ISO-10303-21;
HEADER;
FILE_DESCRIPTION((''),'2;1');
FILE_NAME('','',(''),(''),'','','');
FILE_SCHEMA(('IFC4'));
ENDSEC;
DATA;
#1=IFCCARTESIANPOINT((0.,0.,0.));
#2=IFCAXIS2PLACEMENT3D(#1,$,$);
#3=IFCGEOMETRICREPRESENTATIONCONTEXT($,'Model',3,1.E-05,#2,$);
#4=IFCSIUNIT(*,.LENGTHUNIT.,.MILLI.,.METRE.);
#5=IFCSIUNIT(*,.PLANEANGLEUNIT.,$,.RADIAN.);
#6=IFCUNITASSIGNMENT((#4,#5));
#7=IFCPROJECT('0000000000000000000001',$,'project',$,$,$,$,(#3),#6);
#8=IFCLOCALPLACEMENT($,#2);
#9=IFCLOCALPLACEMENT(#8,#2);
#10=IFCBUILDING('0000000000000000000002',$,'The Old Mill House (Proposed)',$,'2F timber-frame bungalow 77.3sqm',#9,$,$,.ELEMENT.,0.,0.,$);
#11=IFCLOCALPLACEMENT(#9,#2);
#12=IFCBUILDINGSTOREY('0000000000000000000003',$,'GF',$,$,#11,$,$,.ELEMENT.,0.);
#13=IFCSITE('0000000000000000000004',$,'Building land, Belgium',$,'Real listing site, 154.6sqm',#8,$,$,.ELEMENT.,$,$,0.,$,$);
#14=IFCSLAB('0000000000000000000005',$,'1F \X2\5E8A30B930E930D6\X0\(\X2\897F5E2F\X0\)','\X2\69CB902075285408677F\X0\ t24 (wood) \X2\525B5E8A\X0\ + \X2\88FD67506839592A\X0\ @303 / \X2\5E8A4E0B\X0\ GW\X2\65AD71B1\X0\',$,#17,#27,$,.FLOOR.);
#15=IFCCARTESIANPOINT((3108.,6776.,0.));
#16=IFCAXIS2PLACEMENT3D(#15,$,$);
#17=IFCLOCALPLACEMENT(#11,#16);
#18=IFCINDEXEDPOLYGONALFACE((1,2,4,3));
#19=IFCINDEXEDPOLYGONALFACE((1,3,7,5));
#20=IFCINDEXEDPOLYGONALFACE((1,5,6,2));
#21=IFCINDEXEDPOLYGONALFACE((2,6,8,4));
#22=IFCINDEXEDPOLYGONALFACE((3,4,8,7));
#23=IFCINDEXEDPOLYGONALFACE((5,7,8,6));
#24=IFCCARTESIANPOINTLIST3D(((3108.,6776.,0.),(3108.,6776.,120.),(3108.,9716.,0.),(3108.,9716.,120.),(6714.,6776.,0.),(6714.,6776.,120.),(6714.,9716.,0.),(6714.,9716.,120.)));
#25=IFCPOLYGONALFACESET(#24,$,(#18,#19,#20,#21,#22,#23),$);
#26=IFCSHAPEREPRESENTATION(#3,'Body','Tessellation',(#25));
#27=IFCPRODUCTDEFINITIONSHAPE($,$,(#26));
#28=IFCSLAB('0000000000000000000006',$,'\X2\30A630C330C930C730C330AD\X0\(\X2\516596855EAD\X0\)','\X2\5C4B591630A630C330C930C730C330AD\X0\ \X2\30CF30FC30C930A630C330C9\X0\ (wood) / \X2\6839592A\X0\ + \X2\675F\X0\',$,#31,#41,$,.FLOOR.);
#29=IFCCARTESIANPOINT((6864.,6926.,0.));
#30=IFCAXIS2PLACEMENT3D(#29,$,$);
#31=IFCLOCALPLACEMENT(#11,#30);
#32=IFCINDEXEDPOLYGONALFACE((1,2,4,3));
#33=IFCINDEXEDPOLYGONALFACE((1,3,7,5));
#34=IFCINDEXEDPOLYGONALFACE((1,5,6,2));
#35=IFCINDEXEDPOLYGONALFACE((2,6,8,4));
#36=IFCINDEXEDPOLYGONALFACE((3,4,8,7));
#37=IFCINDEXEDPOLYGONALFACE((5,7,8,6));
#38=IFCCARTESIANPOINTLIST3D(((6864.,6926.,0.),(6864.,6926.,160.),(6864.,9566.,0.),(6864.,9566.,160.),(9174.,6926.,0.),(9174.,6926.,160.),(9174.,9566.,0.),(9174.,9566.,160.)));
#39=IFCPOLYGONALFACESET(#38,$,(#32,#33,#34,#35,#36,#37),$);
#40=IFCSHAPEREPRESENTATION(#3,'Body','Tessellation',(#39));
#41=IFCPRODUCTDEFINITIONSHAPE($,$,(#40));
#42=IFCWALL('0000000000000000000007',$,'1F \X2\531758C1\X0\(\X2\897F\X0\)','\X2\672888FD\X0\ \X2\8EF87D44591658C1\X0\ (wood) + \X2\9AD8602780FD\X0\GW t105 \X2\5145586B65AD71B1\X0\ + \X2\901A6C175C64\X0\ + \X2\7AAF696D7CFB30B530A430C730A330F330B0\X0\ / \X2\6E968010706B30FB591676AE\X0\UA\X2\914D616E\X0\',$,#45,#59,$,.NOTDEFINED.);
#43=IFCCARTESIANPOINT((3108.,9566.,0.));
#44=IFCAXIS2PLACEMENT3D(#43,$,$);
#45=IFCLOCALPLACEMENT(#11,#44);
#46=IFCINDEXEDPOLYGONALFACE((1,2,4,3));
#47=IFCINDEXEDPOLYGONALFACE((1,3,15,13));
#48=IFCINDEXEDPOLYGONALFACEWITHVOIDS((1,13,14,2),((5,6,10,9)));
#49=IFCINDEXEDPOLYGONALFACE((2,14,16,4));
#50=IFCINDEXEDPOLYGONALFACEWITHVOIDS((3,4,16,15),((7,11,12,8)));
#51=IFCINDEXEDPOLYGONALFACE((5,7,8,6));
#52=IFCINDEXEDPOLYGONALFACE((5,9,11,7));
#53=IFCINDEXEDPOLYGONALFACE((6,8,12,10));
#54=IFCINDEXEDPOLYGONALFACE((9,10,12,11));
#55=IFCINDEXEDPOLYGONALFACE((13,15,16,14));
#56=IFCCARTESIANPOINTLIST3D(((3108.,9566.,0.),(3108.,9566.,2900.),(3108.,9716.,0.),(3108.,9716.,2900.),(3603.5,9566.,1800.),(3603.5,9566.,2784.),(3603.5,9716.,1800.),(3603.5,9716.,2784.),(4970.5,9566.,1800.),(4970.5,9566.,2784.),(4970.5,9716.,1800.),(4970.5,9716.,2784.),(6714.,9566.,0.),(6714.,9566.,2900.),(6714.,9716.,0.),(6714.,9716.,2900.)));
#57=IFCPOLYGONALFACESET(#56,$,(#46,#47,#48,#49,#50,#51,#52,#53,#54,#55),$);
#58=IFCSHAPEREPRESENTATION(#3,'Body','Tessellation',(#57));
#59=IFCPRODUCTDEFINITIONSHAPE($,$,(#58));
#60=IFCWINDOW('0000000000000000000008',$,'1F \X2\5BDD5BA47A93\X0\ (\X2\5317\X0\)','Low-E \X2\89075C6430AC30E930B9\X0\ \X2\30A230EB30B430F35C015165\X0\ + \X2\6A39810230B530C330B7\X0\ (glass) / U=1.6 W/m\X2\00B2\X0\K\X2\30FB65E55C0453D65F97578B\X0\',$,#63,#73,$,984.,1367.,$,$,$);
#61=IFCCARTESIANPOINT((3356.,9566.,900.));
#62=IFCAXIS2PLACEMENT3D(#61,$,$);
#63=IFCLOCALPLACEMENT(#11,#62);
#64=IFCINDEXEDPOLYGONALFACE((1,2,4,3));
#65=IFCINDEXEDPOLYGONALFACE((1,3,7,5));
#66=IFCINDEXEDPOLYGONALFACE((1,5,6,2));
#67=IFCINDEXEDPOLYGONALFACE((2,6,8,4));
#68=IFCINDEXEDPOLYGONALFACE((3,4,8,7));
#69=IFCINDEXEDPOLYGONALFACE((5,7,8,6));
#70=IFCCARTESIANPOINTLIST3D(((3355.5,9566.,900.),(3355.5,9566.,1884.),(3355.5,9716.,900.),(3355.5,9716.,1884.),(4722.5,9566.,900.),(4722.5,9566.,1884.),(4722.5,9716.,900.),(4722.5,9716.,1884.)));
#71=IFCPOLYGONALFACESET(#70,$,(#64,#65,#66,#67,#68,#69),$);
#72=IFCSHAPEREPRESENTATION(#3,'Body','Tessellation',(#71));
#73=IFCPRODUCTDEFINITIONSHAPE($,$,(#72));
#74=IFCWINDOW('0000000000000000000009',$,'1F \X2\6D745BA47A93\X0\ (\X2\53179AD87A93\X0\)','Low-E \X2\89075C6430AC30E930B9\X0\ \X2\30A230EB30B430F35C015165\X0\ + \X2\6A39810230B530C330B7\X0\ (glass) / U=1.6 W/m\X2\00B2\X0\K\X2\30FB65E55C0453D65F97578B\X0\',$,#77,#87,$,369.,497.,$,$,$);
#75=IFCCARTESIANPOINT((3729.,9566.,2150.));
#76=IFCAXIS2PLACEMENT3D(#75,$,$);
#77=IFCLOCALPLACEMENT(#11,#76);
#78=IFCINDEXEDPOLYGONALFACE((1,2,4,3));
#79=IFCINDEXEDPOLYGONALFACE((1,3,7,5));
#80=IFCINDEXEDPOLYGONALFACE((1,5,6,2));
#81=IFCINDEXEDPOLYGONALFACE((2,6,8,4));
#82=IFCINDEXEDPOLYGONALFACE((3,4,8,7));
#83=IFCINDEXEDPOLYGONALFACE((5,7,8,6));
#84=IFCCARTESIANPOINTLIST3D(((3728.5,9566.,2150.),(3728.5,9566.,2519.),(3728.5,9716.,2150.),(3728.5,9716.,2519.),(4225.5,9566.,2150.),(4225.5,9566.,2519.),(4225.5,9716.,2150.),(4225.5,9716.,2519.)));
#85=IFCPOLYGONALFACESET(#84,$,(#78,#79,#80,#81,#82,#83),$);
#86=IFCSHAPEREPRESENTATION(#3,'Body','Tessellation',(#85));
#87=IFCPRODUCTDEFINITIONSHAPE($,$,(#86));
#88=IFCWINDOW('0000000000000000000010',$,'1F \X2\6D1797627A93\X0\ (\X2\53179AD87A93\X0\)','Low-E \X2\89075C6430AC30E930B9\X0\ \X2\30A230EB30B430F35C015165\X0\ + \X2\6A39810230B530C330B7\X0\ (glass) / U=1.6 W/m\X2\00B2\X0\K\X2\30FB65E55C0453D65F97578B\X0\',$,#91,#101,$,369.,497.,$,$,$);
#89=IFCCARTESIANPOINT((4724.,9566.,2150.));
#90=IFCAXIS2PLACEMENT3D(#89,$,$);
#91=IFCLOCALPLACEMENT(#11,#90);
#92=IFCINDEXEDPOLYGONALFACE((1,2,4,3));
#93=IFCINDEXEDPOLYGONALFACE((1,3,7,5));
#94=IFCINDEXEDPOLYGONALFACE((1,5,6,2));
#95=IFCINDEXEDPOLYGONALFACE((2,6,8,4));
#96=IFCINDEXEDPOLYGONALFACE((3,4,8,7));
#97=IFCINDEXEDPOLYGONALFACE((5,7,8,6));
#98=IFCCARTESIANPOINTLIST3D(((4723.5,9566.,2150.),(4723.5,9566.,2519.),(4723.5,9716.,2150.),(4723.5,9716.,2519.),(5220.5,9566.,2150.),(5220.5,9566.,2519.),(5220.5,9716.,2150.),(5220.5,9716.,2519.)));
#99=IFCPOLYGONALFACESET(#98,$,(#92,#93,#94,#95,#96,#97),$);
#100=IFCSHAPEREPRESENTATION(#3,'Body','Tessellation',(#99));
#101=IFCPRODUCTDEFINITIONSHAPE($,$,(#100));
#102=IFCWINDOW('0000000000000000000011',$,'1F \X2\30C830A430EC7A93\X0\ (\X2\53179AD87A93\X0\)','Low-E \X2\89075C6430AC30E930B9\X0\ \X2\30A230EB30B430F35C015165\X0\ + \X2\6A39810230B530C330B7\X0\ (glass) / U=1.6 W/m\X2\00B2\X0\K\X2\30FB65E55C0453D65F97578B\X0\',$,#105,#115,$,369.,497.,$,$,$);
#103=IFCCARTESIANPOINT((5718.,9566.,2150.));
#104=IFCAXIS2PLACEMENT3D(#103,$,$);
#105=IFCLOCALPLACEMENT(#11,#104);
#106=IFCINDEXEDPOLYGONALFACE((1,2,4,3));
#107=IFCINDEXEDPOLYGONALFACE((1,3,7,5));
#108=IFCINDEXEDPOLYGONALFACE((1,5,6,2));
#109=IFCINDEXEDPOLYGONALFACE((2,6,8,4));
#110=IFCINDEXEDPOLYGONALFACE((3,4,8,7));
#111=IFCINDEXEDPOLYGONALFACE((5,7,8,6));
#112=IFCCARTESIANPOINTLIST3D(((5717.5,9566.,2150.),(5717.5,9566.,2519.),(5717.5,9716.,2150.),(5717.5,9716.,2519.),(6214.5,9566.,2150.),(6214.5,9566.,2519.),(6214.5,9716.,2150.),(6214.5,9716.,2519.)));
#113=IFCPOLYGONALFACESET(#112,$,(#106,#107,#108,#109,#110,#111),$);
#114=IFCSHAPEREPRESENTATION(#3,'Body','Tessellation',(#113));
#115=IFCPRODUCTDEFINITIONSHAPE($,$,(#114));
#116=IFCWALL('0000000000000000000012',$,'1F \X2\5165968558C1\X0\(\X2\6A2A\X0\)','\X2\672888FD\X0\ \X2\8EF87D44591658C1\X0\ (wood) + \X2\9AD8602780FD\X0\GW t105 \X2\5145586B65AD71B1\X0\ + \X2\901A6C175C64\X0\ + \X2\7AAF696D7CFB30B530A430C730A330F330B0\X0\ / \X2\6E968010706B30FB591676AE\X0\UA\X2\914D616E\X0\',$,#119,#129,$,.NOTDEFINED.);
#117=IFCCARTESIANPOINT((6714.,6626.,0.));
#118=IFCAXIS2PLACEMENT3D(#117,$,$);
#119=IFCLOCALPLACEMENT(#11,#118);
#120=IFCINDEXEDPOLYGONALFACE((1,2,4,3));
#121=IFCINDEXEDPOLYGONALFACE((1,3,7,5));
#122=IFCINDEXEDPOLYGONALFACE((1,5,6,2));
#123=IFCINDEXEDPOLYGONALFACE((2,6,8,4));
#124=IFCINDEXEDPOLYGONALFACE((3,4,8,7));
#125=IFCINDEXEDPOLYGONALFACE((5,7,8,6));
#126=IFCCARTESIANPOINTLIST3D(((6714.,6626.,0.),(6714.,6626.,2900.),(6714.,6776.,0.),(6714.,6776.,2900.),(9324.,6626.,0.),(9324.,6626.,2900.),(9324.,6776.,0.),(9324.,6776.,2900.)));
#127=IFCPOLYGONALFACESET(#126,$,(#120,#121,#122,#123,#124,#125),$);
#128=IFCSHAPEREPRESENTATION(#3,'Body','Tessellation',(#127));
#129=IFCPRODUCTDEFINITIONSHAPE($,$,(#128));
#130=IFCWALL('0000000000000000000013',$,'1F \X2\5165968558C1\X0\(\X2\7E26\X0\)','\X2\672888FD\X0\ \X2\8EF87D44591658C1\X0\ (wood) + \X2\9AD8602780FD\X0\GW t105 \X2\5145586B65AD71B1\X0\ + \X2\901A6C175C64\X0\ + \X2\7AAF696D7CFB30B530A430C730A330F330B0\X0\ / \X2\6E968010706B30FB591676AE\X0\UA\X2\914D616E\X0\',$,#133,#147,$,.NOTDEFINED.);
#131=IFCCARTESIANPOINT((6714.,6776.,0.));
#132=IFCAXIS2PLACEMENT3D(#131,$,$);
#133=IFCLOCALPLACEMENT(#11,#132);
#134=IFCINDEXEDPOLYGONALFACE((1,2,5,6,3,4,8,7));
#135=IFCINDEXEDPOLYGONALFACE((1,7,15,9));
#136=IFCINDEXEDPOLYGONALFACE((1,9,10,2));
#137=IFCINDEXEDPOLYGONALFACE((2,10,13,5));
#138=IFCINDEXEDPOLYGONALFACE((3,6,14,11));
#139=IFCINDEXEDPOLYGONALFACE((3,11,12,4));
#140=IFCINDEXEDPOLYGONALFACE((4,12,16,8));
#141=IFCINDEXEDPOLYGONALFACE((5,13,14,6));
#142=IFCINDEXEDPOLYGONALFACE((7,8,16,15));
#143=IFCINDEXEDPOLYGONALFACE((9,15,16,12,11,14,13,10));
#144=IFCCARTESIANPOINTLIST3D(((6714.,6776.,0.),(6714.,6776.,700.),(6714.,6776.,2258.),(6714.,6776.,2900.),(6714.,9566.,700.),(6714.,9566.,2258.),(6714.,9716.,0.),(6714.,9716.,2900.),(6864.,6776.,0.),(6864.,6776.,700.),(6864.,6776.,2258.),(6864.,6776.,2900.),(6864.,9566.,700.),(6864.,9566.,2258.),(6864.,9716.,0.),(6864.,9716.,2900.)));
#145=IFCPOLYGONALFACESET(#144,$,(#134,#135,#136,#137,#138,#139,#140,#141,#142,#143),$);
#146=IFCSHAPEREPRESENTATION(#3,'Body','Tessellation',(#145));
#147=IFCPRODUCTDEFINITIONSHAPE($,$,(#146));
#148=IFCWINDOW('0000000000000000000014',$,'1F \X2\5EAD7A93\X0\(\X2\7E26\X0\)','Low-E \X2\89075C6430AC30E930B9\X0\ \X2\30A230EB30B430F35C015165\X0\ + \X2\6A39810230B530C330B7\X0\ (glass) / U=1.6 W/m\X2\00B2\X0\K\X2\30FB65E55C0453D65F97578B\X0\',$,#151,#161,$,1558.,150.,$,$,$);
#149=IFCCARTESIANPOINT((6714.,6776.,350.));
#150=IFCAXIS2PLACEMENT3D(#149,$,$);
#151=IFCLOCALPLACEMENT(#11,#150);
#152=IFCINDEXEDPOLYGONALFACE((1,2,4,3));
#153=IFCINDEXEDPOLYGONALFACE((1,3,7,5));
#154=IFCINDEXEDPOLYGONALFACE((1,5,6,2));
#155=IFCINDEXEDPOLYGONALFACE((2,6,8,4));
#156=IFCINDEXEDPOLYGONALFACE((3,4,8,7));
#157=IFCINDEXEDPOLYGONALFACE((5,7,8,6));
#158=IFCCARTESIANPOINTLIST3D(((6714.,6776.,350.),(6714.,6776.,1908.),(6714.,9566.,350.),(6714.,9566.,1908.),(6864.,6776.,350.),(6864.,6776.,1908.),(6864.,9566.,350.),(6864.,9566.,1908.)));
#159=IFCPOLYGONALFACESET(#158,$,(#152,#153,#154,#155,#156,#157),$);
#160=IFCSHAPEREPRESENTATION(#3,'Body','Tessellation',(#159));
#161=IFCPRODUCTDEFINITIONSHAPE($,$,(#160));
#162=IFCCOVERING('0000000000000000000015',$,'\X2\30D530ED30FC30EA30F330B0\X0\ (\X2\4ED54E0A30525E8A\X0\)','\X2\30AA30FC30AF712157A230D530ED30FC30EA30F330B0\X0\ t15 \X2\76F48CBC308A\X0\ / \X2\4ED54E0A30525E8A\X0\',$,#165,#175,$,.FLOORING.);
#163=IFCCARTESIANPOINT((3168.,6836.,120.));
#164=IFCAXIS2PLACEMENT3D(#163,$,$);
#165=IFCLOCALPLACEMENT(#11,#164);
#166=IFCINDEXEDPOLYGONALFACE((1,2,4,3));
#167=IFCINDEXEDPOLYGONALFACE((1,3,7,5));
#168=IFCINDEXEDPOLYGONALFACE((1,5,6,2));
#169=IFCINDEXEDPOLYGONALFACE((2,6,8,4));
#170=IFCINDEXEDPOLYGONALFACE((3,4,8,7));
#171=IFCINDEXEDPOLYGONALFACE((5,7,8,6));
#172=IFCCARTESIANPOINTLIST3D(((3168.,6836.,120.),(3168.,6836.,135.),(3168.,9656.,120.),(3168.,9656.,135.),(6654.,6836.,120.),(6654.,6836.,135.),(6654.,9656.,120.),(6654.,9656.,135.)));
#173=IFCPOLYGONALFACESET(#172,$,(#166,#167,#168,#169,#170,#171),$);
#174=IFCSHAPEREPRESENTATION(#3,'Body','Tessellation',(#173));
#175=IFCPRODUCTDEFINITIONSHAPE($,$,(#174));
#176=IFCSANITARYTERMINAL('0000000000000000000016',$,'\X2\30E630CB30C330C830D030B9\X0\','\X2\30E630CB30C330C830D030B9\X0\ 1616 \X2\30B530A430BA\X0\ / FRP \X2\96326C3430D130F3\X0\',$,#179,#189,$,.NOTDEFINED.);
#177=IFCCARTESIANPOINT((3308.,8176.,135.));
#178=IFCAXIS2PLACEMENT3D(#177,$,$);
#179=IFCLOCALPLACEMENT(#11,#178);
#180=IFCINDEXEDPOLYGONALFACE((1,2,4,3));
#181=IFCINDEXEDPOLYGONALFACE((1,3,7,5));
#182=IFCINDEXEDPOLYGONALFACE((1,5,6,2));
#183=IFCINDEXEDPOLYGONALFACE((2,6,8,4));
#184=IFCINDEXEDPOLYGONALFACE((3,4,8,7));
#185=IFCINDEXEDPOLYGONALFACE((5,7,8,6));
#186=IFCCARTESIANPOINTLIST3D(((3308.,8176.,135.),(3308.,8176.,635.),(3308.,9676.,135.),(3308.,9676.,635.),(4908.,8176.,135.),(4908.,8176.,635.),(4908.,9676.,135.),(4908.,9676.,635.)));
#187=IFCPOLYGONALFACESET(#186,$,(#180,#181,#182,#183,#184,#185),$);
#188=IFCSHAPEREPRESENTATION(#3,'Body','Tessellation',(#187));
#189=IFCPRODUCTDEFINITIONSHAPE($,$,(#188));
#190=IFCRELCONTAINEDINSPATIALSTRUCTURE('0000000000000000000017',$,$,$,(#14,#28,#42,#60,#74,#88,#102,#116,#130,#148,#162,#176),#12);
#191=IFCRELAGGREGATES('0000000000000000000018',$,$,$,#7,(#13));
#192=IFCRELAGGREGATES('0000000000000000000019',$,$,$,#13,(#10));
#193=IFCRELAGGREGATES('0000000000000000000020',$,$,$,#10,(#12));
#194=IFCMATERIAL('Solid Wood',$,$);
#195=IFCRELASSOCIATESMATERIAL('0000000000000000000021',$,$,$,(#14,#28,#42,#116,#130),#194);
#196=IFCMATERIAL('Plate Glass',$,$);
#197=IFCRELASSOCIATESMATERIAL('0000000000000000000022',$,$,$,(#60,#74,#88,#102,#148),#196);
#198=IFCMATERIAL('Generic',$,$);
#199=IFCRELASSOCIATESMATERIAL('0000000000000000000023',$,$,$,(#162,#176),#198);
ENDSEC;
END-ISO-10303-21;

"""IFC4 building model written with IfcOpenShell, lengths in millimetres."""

from ifc_helpers import new_model, si_unit, frame, frame_2d, origin, place, context, project, spatial, rectangle, extrude, material, element, fill, save


model = new_model("IFC4")

# Units and contexts
model_context = context("Model", 3, precision=1e-05, world=origin())
ifc_project = project(units=[si_unit("LENGTHUNIT", "METRE", prefix="MILLI"), si_unit("PLANEANGLEUNIT", "RADIAN")], contexts=[model_context])

# Site, building, storey
site_placement = place(None, origin())
site = spatial("IfcSite", under=ifc_project, at=site_placement, Name="Building land, Belgium", ObjectType="Real listing site, 154.6sqm", CompositionType="ELEMENT", RefElevation=0.0)
building_placement = place(site_placement, origin())
building = spatial("IfcBuilding", under=site, at=building_placement, Name="The Old Mill House (Proposed)", ObjectType="2F timber-frame bungalow 77.3sqm", CompositionType="ELEMENT", ElevationOfRefHeight=0.0, ElevationOfTerrain=0.0)
storey_placement = place(building_placement, origin())
storey = spatial("IfcBuildingStorey", under=building, at=storey_placement, Name="GF", CompositionType="ELEMENT", Elevation=0.0)

# Slabs
ifc_material_1 = material(Name="Solid Wood")
slab_1_placement = place(storey_placement, frame((3108.0, 6776.0, 0.0)))
element("IfcSlab", 1, at=slab_1_placement, inside=storey, material=ifc_material_1, Name="1F 床スラブ(西帯)", Description="構造用合板 t24 (wood) 剛床 + 製材根太 @303 / 床下 GW断熱", PredefinedType="FLOOR", context=model_context, shape_type="SweptSolid", body=[
    extrude(rectangle(XDim=3606.0, YDim=2940.0, at=frame_2d((1803.0, 1470.0))), frame((3108.0, 6776.0, 0.0)), (0.0, 0.0, 1.0), 120.0),
])
slab_2_placement = place(storey_placement, frame((6864.0, 6926.0, 0.0)))
element("IfcSlab", 2, at=slab_2_placement, inside=storey, material=ifc_material_1, Name="ウッドデッキ(入隅庭)", Description="屋外ウッドデッキ ハードウッド (wood) / 根太 + 束", PredefinedType="FLOOR", context=model_context, shape_type="SweptSolid", body=[
    extrude(rectangle(XDim=2310.0, YDim=2640.0, at=frame_2d((1155.0, 1320.0))), frame((6864.0, 6926.0, 0.0)), (0.0, 0.0, 1.0), 160.0),
])

# Wall, openings, windows
wall_1_placement = place(storey_placement, frame((3108.0, 9566.0, 0.0)))
wall_1 = element("IfcWall", 3, at=wall_1_placement, inside=storey, material=ifc_material_1, Name="1F 北壁(西)", Description="木製 軸組外壁 (wood) + 高性能GW t105 充填断熱 + 通気層 + 窯業系サイディング / 準耐火・外皮UA配慮", PredefinedType="NOTDEFINED", context=model_context, shape_type="SweptSolid", body=[
    extrude(rectangle(XDim=3606.0, YDim=150.0, at=frame_2d((1803.0, 75.0))), frame((3108.0, 9566.0, 0.0)), (0.0, 0.0, 1.0), 2900.0),
])
opening_1_placement = place(storey_placement, frame((3356.0, 9566.0, 900.0)))
opening_1 = element("IfcOpeningElement", 4, at=opening_1_placement, cuts=wall_1, PredefinedType="NOTDEFINED", context=model_context, shape_type="SweptSolid", body=[
    extrude(rectangle(XDim=1367.0, YDim=150.0, at=frame_2d((683.0, 75.0))), frame((3356.0, 9566.0, 900.0)), (0.0, 0.0, 1.0), 984.0),
])
opening_2_placement = place(storey_placement, frame((3729.0, 9566.0, 2150.0)))
opening_2 = element("IfcOpeningElement", 5, at=opening_2_placement, cuts=wall_1, PredefinedType="NOTDEFINED", context=model_context, shape_type="SweptSolid", body=[
    extrude(rectangle(XDim=497.0, YDim=150.0, at=frame_2d((248.0, 75.0))), frame((3729.0, 9566.0, 2150.0)), (0.0, 0.0, 1.0), 369.0),
])
opening_3_placement = place(storey_placement, frame((4724.0, 9566.0, 2150.0)))
opening_3 = element("IfcOpeningElement", 6, at=opening_3_placement, cuts=wall_1, PredefinedType="NOTDEFINED", context=model_context, shape_type="SweptSolid", body=[
    extrude(rectangle(XDim=497.0, YDim=150.0, at=frame_2d((248.0, 75.0))), frame((4724.0, 9566.0, 2150.0)), (0.0, 0.0, 1.0), 369.0),
])
opening_4_placement = place(storey_placement, frame((5718.0, 9566.0, 2150.0)))
opening_4 = element("IfcOpeningElement", 7, at=opening_4_placement, cuts=wall_1, PredefinedType="NOTDEFINED", context=model_context, shape_type="SweptSolid", body=[
    extrude(rectangle(XDim=497.0, YDim=150.0, at=frame_2d((248.0, 75.0))), frame((5718.0, 9566.0, 2150.0)), (0.0, 0.0, 1.0), 369.0),
])
ifc_material_2 = material(Name="Plate Glass")
window_1_placement = place(storey_placement, frame((3356.0, 9566.0, 900.0)))
window_1 = element("IfcWindow", 8, at=window_1_placement, inside=storey, material=ifc_material_2, Name="1F 寝室窓 (北)", Description="Low-E 複層ガラス アルゴン封入 + 樹脂サッシ (glass) / U=1.6 W/m²K・日射取得型", OverallHeight=984.0, OverallWidth=1367.0, context=model_context, shape_type="SweptSolid", body=[
    extrude(rectangle(XDim=1367.0, YDim=150.0, at=frame_2d((683.0, 75.0))), frame((3356.0, 9566.0, 900.0)), (0.0, 0.0, 1.0), 984.0),
])
fill(opening_1, window_1)
window_2_placement = place(storey_placement, frame((3729.0, 9566.0, 2150.0)))
window_2 = element("IfcWindow", 9, at=window_2_placement, inside=storey, material=ifc_material_2, Name="1F 浴室窓 (北高窓)", Description="Low-E 複層ガラス アルゴン封入 + 樹脂サッシ (glass) / U=1.6 W/m²K・日射取得型", OverallHeight=369.0, OverallWidth=497.0, context=model_context, shape_type="SweptSolid", body=[
    extrude(rectangle(XDim=497.0, YDim=150.0, at=frame_2d((248.0, 75.0))), frame((3729.0, 9566.0, 2150.0)), (0.0, 0.0, 1.0), 369.0),
])
fill(opening_2, window_2)
window_3_placement = place(storey_placement, frame((4724.0, 9566.0, 2150.0)))
window_3 = element("IfcWindow", 10, at=window_3_placement, inside=storey, material=ifc_material_2, Name="1F 洗面窓 (北高窓)", Description="Low-E 複層ガラス アルゴン封入 + 樹脂サッシ (glass) / U=1.6 W/m²K・日射取得型", OverallHeight=369.0, OverallWidth=497.0, context=model_context, shape_type="SweptSolid", body=[
    extrude(rectangle(XDim=497.0, YDim=150.0, at=frame_2d((248.0, 75.0))), frame((4724.0, 9566.0, 2150.0)), (0.0, 0.0, 1.0), 369.0),
])
fill(opening_3, window_3)
window_4_placement = place(storey_placement, frame((5718.0, 9566.0, 2150.0)))
window_4 = element("IfcWindow", 11, at=window_4_placement, inside=storey, material=ifc_material_2, Name="1F トイレ窓 (北高窓)", Description="Low-E 複層ガラス アルゴン封入 + 樹脂サッシ (glass) / U=1.6 W/m²K・日射取得型", OverallHeight=369.0, OverallWidth=497.0, context=model_context, shape_type="SweptSolid", body=[
    extrude(rectangle(XDim=497.0, YDim=150.0, at=frame_2d((248.0, 75.0))), frame((5718.0, 9566.0, 2150.0)), (0.0, 0.0, 1.0), 369.0),
])
fill(opening_4, window_4)

# Wall
wall_2_placement = place(storey_placement, frame((6714.0, 6626.0, 0.0)))
element("IfcWall", 12, at=wall_2_placement, inside=storey, material=ifc_material_1, Name="1F 入隅壁(横)", Description="木製 軸組外壁 (wood) + 高性能GW t105 充填断熱 + 通気層 + 窯業系サイディング / 準耐火・外皮UA配慮", PredefinedType="NOTDEFINED", context=model_context, shape_type="SweptSolid", body=[
    extrude(rectangle(XDim=2610.0, YDim=150.0, at=frame_2d((1305.0, 75.0))), frame((6714.0, 6626.0, 0.0)), (0.0, 0.0, 1.0), 2900.0),
])

# Wall, opening, window
wall_3_placement = place(storey_placement, frame((6714.0, 6776.0, 0.0)))
wall_3 = element("IfcWall", 13, at=wall_3_placement, inside=storey, material=ifc_material_1, Name="1F 入隅壁(縦)", Description="木製 軸組外壁 (wood) + 高性能GW t105 充填断熱 + 通気層 + 窯業系サイディング / 準耐火・外皮UA配慮", PredefinedType="NOTDEFINED", context=model_context, shape_type="SweptSolid", body=[
    extrude(rectangle(XDim=150.0, YDim=2940.0, at=frame_2d((75.0, 1470.0))), frame((6714.0, 6776.0, 0.0)), (0.0, 0.0, 1.0), 2900.0),
])
opening_5_placement = place(storey_placement, frame((6714.0, 6776.0, 350.0)))
opening_5 = element("IfcOpeningElement", 14, at=opening_5_placement, cuts=wall_3, PredefinedType="NOTDEFINED", context=model_context, shape_type="SweptSolid", body=[
    extrude(rectangle(XDim=150.0, YDim=2790.0, at=frame_2d((75.0, 1395.0))), frame((6714.0, 6776.0, 350.0)), (0.0, 0.0, 1.0), 1558.0),
])
window_5_placement = place(storey_placement, frame((6714.0, 6776.0, 350.0)))
window_5 = element("IfcWindow", 15, at=window_5_placement, inside=storey, material=ifc_material_2, Name="1F 庭窓(縦)", Description="Low-E 複層ガラス アルゴン封入 + 樹脂サッシ (glass) / U=1.6 W/m²K・日射取得型", OverallHeight=1558.0, OverallWidth=150.0, context=model_context, shape_type="SweptSolid", body=[
    extrude(rectangle(XDim=150.0, YDim=2790.0, at=frame_2d((75.0, 1395.0))), frame((6714.0, 6776.0, 350.0)), (0.0, 0.0, 1.0), 1558.0),
])
fill(opening_5, window_5)

# Covering
ifc_material_3 = material(Name="Generic")
covering_placement = place(storey_placement, frame((3168.0, 6836.0, 120.0)))
element("IfcCovering", 16, at=covering_placement, inside=storey, material=ifc_material_3, Name="フローリング (仕上げ床)", Description="オーク無垢フローリング t15 直貼り / 仕上げ床", PredefinedType="FLOORING", context=model_context, shape_type="SweptSolid", body=[
    extrude(rectangle(XDim=3486.0, YDim=2820.0, at=frame_2d((1743.0, 1410.0))), frame((3168.0, 6836.0, 120.0)), (0.0, 0.0, 1.0), 15.0),
])

# Sanitary terminal
sanitary_terminal_1_placement = place(storey_placement, frame((3308.0, 8176.0, 135.0)))
element("IfcSanitaryTerminal", 17, at=sanitary_terminal_1_placement, inside=storey, material=ifc_material_3, Name="ユニットバス", Description="ユニットバス 1616 サイズ / FRP 防水パン", PredefinedType="NOTDEFINED", context=model_context, shape_type="SweptSolid", body=[
    extrude(rectangle(XDim=1600.0, YDim=1500.0, at=frame_2d((800.0, 750.0))), frame((3308.0, 8176.0, 135.0)), (0.0, 0.0, 1.0), 500.0),
])

save(model, "model.ifc")
